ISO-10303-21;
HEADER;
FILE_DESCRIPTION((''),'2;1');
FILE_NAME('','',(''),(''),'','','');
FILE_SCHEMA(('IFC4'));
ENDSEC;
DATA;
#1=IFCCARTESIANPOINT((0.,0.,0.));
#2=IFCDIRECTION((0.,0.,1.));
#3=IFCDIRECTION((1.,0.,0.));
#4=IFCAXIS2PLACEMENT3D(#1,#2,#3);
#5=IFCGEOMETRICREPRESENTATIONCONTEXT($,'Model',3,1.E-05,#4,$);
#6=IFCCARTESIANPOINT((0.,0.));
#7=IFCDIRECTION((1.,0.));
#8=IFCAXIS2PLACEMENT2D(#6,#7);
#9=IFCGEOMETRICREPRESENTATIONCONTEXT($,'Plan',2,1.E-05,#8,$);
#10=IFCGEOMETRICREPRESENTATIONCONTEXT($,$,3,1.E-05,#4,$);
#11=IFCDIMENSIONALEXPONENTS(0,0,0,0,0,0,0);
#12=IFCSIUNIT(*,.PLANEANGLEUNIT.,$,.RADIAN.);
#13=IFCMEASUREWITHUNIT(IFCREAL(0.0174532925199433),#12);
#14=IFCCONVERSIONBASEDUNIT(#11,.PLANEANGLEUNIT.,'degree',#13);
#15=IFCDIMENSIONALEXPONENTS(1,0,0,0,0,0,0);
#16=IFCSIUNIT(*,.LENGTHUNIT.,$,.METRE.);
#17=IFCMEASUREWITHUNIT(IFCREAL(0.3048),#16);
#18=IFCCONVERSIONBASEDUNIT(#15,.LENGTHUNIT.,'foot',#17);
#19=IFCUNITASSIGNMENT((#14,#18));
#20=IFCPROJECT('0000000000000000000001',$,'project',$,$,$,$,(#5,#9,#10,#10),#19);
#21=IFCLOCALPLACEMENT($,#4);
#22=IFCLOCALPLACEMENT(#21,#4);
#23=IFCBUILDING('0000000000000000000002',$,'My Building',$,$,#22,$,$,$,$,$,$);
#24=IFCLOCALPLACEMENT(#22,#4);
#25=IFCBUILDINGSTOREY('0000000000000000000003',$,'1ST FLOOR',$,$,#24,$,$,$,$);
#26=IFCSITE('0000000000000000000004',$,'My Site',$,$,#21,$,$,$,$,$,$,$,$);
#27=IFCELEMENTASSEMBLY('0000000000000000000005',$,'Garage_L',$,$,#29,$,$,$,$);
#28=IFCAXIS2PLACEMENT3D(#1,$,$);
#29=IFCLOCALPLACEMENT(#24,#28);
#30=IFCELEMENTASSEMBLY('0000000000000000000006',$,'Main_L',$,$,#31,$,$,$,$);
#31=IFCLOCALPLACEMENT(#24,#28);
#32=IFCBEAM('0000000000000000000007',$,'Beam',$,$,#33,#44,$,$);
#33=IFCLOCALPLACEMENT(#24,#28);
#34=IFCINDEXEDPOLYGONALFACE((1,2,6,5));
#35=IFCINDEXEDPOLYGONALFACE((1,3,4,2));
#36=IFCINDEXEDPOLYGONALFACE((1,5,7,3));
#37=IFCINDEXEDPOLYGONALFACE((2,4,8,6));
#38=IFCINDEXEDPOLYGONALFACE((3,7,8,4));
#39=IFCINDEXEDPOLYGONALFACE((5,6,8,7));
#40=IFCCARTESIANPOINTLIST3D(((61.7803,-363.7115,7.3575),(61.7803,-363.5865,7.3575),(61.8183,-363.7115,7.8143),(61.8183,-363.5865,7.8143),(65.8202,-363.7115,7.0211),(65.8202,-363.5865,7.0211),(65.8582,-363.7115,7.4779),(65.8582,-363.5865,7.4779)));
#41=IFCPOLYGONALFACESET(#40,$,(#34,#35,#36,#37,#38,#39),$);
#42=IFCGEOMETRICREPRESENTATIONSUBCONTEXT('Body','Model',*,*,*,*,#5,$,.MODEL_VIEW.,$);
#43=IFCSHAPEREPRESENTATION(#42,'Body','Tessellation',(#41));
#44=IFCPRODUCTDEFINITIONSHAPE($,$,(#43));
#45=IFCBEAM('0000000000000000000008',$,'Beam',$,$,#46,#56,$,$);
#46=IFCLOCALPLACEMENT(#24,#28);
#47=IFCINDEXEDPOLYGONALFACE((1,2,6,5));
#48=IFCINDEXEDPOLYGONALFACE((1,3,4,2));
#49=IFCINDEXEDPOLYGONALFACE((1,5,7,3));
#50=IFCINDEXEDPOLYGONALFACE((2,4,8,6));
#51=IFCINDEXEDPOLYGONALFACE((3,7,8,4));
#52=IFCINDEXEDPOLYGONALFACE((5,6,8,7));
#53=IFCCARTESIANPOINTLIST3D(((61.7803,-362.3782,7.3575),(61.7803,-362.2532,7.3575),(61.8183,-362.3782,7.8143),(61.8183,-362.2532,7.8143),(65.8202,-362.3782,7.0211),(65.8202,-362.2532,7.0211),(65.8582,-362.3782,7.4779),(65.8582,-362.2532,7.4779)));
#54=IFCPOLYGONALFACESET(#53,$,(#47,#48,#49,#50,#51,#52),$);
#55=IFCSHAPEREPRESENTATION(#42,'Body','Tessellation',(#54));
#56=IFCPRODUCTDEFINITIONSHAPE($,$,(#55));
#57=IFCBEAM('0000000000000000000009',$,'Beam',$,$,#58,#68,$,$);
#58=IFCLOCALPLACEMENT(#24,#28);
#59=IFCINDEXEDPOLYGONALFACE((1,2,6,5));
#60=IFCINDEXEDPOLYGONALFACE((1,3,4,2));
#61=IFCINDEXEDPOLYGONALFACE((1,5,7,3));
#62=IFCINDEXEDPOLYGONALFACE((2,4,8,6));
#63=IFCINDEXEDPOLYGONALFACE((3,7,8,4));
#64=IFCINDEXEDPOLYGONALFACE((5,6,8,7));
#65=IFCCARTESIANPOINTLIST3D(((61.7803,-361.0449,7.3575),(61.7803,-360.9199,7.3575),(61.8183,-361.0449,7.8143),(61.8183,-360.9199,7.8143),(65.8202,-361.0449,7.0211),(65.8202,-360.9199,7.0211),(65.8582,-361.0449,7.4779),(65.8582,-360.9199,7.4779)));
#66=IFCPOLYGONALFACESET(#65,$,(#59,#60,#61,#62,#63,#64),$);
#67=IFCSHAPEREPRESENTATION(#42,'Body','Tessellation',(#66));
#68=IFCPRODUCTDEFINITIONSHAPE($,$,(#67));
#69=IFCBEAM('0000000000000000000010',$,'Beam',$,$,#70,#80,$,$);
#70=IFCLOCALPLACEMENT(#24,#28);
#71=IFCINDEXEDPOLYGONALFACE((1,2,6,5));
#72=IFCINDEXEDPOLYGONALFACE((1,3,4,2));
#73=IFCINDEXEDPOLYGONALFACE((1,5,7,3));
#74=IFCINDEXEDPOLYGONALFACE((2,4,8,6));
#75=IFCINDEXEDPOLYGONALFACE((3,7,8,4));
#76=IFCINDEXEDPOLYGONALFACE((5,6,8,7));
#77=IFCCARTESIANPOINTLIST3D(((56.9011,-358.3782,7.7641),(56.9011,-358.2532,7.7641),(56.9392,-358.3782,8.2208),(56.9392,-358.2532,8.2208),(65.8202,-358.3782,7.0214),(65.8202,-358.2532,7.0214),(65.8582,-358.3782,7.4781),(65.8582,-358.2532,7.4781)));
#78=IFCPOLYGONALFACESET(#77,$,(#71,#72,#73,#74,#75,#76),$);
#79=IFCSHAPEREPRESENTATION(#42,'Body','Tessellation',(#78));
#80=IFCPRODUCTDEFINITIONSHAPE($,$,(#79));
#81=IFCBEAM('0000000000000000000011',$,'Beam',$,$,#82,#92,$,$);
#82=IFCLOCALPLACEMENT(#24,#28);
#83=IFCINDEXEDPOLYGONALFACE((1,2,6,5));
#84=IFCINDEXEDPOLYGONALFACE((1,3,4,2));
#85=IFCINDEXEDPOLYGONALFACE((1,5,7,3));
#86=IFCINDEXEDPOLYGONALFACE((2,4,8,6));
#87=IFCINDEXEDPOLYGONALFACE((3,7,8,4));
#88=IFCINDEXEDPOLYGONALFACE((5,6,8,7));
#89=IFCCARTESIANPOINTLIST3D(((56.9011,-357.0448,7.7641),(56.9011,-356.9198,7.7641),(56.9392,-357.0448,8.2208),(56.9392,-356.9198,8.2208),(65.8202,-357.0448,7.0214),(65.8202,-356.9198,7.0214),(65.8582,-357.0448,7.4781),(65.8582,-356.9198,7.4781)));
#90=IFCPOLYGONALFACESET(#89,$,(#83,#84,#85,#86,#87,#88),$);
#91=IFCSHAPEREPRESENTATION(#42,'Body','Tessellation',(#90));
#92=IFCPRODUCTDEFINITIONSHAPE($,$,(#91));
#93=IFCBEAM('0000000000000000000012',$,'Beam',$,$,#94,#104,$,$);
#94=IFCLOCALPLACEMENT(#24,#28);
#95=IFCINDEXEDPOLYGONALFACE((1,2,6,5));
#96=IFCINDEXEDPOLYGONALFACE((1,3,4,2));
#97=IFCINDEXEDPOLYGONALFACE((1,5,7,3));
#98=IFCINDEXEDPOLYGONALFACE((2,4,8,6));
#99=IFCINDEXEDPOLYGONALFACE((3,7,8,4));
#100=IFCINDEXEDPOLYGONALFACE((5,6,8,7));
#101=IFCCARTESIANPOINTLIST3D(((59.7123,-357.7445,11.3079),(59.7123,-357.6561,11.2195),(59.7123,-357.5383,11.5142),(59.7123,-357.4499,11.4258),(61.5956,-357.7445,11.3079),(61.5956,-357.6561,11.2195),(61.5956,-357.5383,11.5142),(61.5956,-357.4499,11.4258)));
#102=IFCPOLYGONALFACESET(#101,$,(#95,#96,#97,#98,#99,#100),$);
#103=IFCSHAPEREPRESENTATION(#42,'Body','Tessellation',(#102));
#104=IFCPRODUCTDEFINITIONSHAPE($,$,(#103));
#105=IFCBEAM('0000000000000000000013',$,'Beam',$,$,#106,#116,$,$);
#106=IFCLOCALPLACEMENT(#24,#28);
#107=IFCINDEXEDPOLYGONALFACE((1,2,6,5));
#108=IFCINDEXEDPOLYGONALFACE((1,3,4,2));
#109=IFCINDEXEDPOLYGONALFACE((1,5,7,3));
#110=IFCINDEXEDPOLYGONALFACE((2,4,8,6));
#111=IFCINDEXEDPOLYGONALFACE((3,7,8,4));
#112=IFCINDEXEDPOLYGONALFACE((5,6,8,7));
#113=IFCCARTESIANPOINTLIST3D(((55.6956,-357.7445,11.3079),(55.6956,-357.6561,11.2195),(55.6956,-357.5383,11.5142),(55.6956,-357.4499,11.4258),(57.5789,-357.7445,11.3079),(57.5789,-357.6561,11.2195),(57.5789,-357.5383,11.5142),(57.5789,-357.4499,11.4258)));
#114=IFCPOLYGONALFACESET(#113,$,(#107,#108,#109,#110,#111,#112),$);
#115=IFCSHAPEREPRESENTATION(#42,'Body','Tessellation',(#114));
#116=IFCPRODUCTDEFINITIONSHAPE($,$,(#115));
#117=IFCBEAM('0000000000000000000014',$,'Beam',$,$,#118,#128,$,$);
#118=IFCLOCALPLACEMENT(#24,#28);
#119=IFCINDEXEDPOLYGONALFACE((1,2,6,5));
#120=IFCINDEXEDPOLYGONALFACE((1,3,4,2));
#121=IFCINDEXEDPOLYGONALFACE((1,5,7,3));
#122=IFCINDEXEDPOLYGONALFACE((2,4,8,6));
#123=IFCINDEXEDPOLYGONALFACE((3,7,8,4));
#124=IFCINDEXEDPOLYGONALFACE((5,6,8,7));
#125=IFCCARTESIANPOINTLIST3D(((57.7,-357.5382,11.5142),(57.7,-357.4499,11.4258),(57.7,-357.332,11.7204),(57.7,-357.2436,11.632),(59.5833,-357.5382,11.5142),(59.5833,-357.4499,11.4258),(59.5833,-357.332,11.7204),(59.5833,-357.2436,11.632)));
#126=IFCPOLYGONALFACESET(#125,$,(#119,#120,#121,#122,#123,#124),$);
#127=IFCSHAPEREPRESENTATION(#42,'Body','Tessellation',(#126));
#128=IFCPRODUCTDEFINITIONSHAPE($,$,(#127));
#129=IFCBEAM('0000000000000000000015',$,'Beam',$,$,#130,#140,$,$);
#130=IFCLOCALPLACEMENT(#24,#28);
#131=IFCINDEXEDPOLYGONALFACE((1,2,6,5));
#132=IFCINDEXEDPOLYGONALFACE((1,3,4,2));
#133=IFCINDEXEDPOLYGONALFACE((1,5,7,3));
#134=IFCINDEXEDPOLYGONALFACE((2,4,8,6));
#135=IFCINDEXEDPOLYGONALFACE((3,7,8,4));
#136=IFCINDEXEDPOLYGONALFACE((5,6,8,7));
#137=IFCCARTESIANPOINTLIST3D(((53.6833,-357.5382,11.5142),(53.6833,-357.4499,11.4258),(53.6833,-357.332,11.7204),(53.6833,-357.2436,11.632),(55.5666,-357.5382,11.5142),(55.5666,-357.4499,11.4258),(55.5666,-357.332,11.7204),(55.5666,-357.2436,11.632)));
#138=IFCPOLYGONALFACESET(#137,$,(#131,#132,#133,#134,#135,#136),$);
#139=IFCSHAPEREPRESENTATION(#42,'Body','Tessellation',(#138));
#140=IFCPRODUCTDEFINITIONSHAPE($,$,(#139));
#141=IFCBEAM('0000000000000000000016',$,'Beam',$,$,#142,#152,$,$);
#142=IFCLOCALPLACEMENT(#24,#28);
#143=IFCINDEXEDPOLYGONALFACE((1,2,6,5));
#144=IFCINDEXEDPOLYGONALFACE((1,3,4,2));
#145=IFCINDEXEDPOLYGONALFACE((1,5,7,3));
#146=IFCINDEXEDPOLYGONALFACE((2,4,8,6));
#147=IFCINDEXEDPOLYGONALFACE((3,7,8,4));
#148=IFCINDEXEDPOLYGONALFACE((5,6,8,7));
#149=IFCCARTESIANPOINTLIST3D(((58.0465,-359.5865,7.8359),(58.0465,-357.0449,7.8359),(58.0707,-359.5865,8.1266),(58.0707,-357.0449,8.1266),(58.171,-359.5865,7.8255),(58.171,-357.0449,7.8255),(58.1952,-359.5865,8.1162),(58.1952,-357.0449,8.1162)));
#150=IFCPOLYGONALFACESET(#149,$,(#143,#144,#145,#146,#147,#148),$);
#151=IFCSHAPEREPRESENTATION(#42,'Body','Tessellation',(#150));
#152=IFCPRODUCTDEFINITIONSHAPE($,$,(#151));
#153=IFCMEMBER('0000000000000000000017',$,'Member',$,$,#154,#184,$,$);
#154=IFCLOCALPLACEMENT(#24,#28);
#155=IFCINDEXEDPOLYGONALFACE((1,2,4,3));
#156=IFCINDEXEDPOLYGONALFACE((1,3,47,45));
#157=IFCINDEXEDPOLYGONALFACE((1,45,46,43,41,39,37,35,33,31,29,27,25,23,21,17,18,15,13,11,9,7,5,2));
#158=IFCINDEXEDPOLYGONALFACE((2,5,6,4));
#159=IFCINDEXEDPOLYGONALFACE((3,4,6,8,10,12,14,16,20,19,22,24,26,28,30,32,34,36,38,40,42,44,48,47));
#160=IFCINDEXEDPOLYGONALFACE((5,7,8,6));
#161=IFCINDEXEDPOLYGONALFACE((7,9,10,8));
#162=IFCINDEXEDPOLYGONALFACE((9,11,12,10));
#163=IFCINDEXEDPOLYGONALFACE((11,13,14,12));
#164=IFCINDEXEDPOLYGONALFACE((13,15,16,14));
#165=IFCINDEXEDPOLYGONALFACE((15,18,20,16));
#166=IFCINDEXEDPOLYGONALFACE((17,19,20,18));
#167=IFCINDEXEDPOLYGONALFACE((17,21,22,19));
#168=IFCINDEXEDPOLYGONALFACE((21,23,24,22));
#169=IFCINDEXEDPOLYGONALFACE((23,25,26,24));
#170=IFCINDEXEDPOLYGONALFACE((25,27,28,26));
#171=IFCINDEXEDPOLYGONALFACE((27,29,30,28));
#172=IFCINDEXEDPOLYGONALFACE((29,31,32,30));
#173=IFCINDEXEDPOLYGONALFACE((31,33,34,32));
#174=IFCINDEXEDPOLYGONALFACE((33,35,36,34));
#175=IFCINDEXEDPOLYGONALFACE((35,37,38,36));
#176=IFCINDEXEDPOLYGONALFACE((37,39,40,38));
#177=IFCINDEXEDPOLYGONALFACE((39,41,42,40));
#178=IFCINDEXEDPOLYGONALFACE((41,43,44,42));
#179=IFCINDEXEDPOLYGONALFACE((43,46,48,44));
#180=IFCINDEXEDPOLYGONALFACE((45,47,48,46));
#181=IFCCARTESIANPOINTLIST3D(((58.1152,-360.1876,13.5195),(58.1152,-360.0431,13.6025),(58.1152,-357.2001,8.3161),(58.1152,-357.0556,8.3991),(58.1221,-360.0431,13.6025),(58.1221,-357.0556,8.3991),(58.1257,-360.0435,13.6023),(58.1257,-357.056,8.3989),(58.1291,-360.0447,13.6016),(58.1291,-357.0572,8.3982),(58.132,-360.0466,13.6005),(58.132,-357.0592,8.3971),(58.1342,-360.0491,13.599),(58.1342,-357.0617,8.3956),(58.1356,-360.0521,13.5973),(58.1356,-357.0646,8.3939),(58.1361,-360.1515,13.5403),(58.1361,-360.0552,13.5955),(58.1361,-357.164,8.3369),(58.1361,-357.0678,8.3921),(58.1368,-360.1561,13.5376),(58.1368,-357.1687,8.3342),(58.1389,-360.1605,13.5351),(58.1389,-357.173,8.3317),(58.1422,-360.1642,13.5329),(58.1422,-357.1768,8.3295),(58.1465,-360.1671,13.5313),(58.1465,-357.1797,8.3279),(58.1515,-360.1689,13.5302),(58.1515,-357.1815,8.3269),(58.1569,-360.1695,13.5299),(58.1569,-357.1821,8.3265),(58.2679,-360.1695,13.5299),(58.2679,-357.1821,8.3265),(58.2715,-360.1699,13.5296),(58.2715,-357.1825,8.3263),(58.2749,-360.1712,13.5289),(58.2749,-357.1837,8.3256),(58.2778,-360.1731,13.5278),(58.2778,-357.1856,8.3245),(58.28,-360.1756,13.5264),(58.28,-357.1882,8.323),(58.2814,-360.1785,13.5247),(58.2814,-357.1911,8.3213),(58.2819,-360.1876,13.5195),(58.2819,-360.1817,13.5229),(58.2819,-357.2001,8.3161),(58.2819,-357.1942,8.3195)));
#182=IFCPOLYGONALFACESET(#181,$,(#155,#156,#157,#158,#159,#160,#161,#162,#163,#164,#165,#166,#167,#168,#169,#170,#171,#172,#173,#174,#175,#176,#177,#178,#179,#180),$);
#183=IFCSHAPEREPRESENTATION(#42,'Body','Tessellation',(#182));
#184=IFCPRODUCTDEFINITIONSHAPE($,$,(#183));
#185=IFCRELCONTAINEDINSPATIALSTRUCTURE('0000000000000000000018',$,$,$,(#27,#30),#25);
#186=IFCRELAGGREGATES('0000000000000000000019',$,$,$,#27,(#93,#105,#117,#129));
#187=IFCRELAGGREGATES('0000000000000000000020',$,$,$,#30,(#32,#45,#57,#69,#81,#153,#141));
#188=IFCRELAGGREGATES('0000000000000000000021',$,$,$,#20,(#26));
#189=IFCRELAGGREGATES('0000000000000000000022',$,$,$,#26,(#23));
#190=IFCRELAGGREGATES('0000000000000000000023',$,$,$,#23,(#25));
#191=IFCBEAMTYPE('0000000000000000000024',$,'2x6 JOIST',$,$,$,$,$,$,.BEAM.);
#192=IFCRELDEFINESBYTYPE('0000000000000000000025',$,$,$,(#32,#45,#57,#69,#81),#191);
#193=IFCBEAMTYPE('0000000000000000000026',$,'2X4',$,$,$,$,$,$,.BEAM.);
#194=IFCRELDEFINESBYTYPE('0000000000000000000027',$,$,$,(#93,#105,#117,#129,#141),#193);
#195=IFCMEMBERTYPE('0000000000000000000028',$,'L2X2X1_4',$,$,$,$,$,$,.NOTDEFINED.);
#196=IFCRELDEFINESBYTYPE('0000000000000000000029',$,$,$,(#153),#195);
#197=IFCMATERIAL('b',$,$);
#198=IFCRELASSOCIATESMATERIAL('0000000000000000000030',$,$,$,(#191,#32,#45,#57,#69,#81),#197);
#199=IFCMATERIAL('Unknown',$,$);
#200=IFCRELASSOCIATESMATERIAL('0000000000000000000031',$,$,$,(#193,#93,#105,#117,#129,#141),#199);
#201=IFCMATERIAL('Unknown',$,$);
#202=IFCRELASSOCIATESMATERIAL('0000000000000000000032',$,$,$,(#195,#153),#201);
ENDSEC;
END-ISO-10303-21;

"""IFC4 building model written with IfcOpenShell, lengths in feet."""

from ifc_helpers import new_model, entity, si_unit, converted_unit, frame, origin_with_axes, origin_2d_with_axis, place, context, subcontext, project, spatial, rectangle, l_section, extrude, material, material_profile, profile_set, profile_usage, type_object, element, aggregate, save


model = new_model("IFC4")

# Units and contexts
model_context = context("Model", 3, precision=1e-05, world=origin_with_axes())
plan_context = context("Plan", 2, precision=1e-05, world=origin_2d_with_axis())
context_of_model = context(None, 3, precision=1e-05, world=origin_with_axes())
body_context = subcontext(model_context, "Body", "Model", "MODEL_VIEW")
ifc_project = project(units=[converted_unit("PLANEANGLEUNIT", "degree", entity("IfcReal", 0.0174532925199433), si_unit("PLANEANGLEUNIT", "RADIAN"), dimensions=[0, 0, 0, 0, 0, 0, 0]), converted_unit("LENGTHUNIT", "foot", entity("IfcReal", 0.3048), si_unit("LENGTHUNIT", "METRE"), dimensions=[1, 0, 0, 0, 0, 0, 0])], contexts=[model_context, plan_context, context_of_model, context_of_model])

# Site, building, storey
site_placement = place(None, origin_with_axes())
site = spatial("IfcSite", under=ifc_project, at=site_placement, Name="My Site")
building_placement = place(site_placement, origin_with_axes())
building = spatial("IfcBuilding", under=site, at=building_placement, Name="My Building")
storey_placement = place(building_placement, origin_with_axes())
storey = spatial("IfcBuildingStorey", under=building, at=storey_placement, Name="1ST FLOOR")

# Element assemblies, beams
assembly_1_placement = place(storey_placement, origin_with_axes())
assembly_1 = element("IfcElementAssembly", 1, at=assembly_1_placement, inside=storey, Name="Garage_L")
ifc_material_1 = material(Name="b")
ifc_material_profile_1 = material_profile(ifc_material_1, rectangle(XDim=0.125, YDim=0.4583))
ifc_profile_set_1 = profile_set([ifc_material_profile_1])
beam_type_1 = type_object("IfcBeamType", Name="2x6 JOIST", PredefinedType="BEAM", material=ifc_profile_set_1)
assembly_2_placement = place(storey_placement, origin_with_axes())
assembly_2 = element("IfcElementAssembly", 2, at=assembly_2_placement, inside=storey, Name="Main_L")
ifc_profile_usage_1 = profile_usage(ifc_profile_set_1)
beam_1_placement = place(assembly_2_placement, frame((61.7993, -363.649, 7.5859), z_axis=(0.996551, 0.0, -0.082982), x_axis=(0.0, 1.0, 0.0)))
beam_1 = element("IfcBeam", 3, at=beam_1_placement, type_object=beam_type_1, material=ifc_profile_usage_1, Name="Beam", context=body_context, shape_type="SweptSolid", body=[
    extrude(rectangle(XDim=0.125, YDim=0.4583), origin_with_axes(), (0.0, 0.0, 1.0), 4.0539),
])
ifc_profile_usage_2 = profile_usage(ifc_profile_set_1)
beam_2_placement = place(assembly_2_placement, frame((61.7993, -362.3157, 7.5859), z_axis=(0.996551, 0.0, -0.082982), x_axis=(0.0, 1.0, 0.0)))
beam_2 = element("IfcBeam", 4, at=beam_2_placement, type_object=beam_type_1, material=ifc_profile_usage_2, Name="Beam", context=body_context, shape_type="SweptSolid", body=[
    extrude(rectangle(XDim=0.125, YDim=0.4583), origin_with_axes(), (0.0, 0.0, 1.0), 4.0539),
])
ifc_profile_usage_3 = profile_usage(ifc_profile_set_1)
beam_3_placement = place(assembly_2_placement, frame((61.7993, -360.9824, 7.5859), z_axis=(0.996551, 0.0, -0.082982), x_axis=(0.0, 1.0, 0.0)))
beam_3 = element("IfcBeam", 5, at=beam_3_placement, type_object=beam_type_1, material=ifc_profile_usage_3, Name="Beam", context=body_context, shape_type="SweptSolid", body=[
    extrude(rectangle(XDim=0.125, YDim=0.4583), origin_with_axes(), (0.0, 0.0, 1.0), 4.0539),
])
ifc_profile_usage_4 = profile_usage(ifc_profile_set_1)
beam_4_placement = place(assembly_2_placement, frame((56.9201, -358.3157, 7.9924), z_axis=(0.996551, 0.0, -0.082982), x_axis=(0.0, 1.0, 0.0)))
beam_4 = element("IfcBeam", 6, at=beam_4_placement, type_object=beam_type_1, material=ifc_profile_usage_4, Name="Beam", context=body_context, shape_type="SweptSolid", body=[
    extrude(rectangle(XDim=0.125, YDim=0.4583), origin_with_axes(), (0.0, 0.0, 1.0), 8.9499),
])
ifc_profile_usage_5 = profile_usage(ifc_profile_set_1)
beam_5_placement = place(assembly_2_placement, frame((56.9201, -356.9823, 7.9924), z_axis=(0.996551, 0.0, -0.082982), x_axis=(0.0, 1.0, 0.0)))
beam_5 = element("IfcBeam", 7, at=beam_5_placement, type_object=beam_type_1, material=ifc_profile_usage_5, Name="Beam", context=body_context, shape_type="SweptSolid", body=[
    extrude(rectangle(XDim=0.125, YDim=0.4583), origin_with_axes(), (0.0, 0.0, 1.0), 8.9499),
])

# Beams
ifc_material_2 = material(Name="Unknown")
ifc_material_profile_2 = material_profile(ifc_material_2, rectangle(XDim=0.125, YDim=0.2917))
ifc_profile_set_2 = profile_set([ifc_material_profile_2])
ifc_profile_usage_6 = profile_usage(ifc_profile_set_2, cardinal=5)
beam_type_2 = type_object("IfcBeamType", Name="2X4", PredefinedType="BEAM", material=ifc_profile_set_2)
beam_6_placement = place(assembly_1_placement, frame((61.5956, -357.5972, 11.3668), z_axis=(-1.0, 0.0, 0.0), x_axis=(0.0, 0.707107, -0.707107)))
beam_6 = element("IfcBeam", 8, at=beam_6_placement, type_object=beam_type_2, material=ifc_profile_usage_6, Name="Beam", context=body_context, shape_type="SweptSolid", body=[
    extrude(rectangle(XDim=0.125, YDim=0.2917), origin_with_axes(), (0.0, 0.0, 1.0), 1.8833),
])
ifc_profile_usage_7 = profile_usage(ifc_profile_set_2, cardinal=5)
beam_7_placement = place(assembly_1_placement, frame((57.5789, -357.5972, 11.3668), z_axis=(-1.0, 0.0, 0.0), x_axis=(0.0, 0.707107, -0.707107)))
beam_7 = element("IfcBeam", 9, at=beam_7_placement, type_object=beam_type_2, material=ifc_profile_usage_7, Name="Beam", context=body_context, shape_type="SweptSolid", body=[
    extrude(rectangle(XDim=0.125, YDim=0.2917), origin_with_axes(), (0.0, 0.0, 1.0), 1.8833),
])
ifc_profile_usage_8 = profile_usage(ifc_profile_set_2, cardinal=5)
beam_8_placement = place(assembly_1_placement, frame((59.5833, -357.3909, 11.5731), z_axis=(-1.0, 0.0, 0.0), x_axis=(0.0, 0.707107, -0.707107)))
beam_8 = element("IfcBeam", 10, at=beam_8_placement, type_object=beam_type_2, material=ifc_profile_usage_8, Name="Beam", context=body_context, shape_type="SweptSolid", body=[
    extrude(rectangle(XDim=0.125, YDim=0.2917), origin_with_axes(), (0.0, 0.0, 1.0), 1.8833),
])
ifc_profile_usage_9 = profile_usage(ifc_profile_set_2, cardinal=5)
beam_9_placement = place(assembly_1_placement, frame((55.5666, -357.3909, 11.5731), z_axis=(-1.0, 0.0, 0.0), x_axis=(0.0, 0.707107, -0.707107)))
beam_9 = element("IfcBeam", 11, at=beam_9_placement, type_object=beam_type_2, material=ifc_profile_usage_9, Name="Beam", context=body_context, shape_type="SweptSolid", body=[
    extrude(rectangle(XDim=0.125, YDim=0.2917), origin_with_axes(), (0.0, 0.0, 1.0), 1.8833),
])
ifc_profile_usage_10 = profile_usage(ifc_profile_set_2)
beam_10_placement = place(assembly_2_placement, frame((58.1209, -359.5865, 7.9761), z_axis=(-0.000001, 1.0, 0.0), x_axis=(-0.996551, -0.000001, 0.082982)))
beam_10 = element("IfcBeam", 12, at=beam_10_placement, type_object=beam_type_2, material=ifc_profile_usage_10, Name="Beam", context=body_context, shape_type="SweptSolid", body=[
    extrude(rectangle(XDim=0.125, YDim=0.2917), origin_with_axes(), (0.0, 0.0, 1.0), 2.5417),
])

# Member
ifc_material_3 = material(Name="Unknown")
ifc_material_profile_3 = material_profile(ifc_material_3, l_section(Depth=0.1667, Width=0.1667, Thickness=0.0208, FilletRadius=0.0208, EdgeRadius=0.014))
ifc_profile_set_3 = profile_set([ifc_material_profile_3])
ifc_profile_usage_11 = profile_usage(ifc_profile_set_3, cardinal=5)
member_type_1 = type_object("IfcMemberType", Name="L2X2X1_4", PredefinedType="NOTDEFINED", material=ifc_profile_set_3)
member_1_placement = place(assembly_2_placement, frame((58.1986, -357.1279, 8.3576), z_axis=(0.0, -0.497908, 0.86723), x_axis=(1.0, 0.0, 0.0)))
member_1 = element("IfcMember", 13, at=member_1_placement, type_object=member_type_1, material=ifc_profile_usage_11, Name="Member", context=body_context, shape_type="SweptSolid", body=[
    extrude(l_section(Depth=0.1667, Width=0.1667, Thickness=0.0208, FilletRadius=0.0208, EdgeRadius=0.014), origin_with_axes(), (0.0, 0.0, 1.0), 6.0),
])

aggregate(assembly_1, [beam_6, beam_7, beam_8, beam_9])

aggregate(assembly_2, [beam_1, beam_2, beam_3, beam_4, beam_5, member_1, beam_10])

save(model, "model.ifc")
